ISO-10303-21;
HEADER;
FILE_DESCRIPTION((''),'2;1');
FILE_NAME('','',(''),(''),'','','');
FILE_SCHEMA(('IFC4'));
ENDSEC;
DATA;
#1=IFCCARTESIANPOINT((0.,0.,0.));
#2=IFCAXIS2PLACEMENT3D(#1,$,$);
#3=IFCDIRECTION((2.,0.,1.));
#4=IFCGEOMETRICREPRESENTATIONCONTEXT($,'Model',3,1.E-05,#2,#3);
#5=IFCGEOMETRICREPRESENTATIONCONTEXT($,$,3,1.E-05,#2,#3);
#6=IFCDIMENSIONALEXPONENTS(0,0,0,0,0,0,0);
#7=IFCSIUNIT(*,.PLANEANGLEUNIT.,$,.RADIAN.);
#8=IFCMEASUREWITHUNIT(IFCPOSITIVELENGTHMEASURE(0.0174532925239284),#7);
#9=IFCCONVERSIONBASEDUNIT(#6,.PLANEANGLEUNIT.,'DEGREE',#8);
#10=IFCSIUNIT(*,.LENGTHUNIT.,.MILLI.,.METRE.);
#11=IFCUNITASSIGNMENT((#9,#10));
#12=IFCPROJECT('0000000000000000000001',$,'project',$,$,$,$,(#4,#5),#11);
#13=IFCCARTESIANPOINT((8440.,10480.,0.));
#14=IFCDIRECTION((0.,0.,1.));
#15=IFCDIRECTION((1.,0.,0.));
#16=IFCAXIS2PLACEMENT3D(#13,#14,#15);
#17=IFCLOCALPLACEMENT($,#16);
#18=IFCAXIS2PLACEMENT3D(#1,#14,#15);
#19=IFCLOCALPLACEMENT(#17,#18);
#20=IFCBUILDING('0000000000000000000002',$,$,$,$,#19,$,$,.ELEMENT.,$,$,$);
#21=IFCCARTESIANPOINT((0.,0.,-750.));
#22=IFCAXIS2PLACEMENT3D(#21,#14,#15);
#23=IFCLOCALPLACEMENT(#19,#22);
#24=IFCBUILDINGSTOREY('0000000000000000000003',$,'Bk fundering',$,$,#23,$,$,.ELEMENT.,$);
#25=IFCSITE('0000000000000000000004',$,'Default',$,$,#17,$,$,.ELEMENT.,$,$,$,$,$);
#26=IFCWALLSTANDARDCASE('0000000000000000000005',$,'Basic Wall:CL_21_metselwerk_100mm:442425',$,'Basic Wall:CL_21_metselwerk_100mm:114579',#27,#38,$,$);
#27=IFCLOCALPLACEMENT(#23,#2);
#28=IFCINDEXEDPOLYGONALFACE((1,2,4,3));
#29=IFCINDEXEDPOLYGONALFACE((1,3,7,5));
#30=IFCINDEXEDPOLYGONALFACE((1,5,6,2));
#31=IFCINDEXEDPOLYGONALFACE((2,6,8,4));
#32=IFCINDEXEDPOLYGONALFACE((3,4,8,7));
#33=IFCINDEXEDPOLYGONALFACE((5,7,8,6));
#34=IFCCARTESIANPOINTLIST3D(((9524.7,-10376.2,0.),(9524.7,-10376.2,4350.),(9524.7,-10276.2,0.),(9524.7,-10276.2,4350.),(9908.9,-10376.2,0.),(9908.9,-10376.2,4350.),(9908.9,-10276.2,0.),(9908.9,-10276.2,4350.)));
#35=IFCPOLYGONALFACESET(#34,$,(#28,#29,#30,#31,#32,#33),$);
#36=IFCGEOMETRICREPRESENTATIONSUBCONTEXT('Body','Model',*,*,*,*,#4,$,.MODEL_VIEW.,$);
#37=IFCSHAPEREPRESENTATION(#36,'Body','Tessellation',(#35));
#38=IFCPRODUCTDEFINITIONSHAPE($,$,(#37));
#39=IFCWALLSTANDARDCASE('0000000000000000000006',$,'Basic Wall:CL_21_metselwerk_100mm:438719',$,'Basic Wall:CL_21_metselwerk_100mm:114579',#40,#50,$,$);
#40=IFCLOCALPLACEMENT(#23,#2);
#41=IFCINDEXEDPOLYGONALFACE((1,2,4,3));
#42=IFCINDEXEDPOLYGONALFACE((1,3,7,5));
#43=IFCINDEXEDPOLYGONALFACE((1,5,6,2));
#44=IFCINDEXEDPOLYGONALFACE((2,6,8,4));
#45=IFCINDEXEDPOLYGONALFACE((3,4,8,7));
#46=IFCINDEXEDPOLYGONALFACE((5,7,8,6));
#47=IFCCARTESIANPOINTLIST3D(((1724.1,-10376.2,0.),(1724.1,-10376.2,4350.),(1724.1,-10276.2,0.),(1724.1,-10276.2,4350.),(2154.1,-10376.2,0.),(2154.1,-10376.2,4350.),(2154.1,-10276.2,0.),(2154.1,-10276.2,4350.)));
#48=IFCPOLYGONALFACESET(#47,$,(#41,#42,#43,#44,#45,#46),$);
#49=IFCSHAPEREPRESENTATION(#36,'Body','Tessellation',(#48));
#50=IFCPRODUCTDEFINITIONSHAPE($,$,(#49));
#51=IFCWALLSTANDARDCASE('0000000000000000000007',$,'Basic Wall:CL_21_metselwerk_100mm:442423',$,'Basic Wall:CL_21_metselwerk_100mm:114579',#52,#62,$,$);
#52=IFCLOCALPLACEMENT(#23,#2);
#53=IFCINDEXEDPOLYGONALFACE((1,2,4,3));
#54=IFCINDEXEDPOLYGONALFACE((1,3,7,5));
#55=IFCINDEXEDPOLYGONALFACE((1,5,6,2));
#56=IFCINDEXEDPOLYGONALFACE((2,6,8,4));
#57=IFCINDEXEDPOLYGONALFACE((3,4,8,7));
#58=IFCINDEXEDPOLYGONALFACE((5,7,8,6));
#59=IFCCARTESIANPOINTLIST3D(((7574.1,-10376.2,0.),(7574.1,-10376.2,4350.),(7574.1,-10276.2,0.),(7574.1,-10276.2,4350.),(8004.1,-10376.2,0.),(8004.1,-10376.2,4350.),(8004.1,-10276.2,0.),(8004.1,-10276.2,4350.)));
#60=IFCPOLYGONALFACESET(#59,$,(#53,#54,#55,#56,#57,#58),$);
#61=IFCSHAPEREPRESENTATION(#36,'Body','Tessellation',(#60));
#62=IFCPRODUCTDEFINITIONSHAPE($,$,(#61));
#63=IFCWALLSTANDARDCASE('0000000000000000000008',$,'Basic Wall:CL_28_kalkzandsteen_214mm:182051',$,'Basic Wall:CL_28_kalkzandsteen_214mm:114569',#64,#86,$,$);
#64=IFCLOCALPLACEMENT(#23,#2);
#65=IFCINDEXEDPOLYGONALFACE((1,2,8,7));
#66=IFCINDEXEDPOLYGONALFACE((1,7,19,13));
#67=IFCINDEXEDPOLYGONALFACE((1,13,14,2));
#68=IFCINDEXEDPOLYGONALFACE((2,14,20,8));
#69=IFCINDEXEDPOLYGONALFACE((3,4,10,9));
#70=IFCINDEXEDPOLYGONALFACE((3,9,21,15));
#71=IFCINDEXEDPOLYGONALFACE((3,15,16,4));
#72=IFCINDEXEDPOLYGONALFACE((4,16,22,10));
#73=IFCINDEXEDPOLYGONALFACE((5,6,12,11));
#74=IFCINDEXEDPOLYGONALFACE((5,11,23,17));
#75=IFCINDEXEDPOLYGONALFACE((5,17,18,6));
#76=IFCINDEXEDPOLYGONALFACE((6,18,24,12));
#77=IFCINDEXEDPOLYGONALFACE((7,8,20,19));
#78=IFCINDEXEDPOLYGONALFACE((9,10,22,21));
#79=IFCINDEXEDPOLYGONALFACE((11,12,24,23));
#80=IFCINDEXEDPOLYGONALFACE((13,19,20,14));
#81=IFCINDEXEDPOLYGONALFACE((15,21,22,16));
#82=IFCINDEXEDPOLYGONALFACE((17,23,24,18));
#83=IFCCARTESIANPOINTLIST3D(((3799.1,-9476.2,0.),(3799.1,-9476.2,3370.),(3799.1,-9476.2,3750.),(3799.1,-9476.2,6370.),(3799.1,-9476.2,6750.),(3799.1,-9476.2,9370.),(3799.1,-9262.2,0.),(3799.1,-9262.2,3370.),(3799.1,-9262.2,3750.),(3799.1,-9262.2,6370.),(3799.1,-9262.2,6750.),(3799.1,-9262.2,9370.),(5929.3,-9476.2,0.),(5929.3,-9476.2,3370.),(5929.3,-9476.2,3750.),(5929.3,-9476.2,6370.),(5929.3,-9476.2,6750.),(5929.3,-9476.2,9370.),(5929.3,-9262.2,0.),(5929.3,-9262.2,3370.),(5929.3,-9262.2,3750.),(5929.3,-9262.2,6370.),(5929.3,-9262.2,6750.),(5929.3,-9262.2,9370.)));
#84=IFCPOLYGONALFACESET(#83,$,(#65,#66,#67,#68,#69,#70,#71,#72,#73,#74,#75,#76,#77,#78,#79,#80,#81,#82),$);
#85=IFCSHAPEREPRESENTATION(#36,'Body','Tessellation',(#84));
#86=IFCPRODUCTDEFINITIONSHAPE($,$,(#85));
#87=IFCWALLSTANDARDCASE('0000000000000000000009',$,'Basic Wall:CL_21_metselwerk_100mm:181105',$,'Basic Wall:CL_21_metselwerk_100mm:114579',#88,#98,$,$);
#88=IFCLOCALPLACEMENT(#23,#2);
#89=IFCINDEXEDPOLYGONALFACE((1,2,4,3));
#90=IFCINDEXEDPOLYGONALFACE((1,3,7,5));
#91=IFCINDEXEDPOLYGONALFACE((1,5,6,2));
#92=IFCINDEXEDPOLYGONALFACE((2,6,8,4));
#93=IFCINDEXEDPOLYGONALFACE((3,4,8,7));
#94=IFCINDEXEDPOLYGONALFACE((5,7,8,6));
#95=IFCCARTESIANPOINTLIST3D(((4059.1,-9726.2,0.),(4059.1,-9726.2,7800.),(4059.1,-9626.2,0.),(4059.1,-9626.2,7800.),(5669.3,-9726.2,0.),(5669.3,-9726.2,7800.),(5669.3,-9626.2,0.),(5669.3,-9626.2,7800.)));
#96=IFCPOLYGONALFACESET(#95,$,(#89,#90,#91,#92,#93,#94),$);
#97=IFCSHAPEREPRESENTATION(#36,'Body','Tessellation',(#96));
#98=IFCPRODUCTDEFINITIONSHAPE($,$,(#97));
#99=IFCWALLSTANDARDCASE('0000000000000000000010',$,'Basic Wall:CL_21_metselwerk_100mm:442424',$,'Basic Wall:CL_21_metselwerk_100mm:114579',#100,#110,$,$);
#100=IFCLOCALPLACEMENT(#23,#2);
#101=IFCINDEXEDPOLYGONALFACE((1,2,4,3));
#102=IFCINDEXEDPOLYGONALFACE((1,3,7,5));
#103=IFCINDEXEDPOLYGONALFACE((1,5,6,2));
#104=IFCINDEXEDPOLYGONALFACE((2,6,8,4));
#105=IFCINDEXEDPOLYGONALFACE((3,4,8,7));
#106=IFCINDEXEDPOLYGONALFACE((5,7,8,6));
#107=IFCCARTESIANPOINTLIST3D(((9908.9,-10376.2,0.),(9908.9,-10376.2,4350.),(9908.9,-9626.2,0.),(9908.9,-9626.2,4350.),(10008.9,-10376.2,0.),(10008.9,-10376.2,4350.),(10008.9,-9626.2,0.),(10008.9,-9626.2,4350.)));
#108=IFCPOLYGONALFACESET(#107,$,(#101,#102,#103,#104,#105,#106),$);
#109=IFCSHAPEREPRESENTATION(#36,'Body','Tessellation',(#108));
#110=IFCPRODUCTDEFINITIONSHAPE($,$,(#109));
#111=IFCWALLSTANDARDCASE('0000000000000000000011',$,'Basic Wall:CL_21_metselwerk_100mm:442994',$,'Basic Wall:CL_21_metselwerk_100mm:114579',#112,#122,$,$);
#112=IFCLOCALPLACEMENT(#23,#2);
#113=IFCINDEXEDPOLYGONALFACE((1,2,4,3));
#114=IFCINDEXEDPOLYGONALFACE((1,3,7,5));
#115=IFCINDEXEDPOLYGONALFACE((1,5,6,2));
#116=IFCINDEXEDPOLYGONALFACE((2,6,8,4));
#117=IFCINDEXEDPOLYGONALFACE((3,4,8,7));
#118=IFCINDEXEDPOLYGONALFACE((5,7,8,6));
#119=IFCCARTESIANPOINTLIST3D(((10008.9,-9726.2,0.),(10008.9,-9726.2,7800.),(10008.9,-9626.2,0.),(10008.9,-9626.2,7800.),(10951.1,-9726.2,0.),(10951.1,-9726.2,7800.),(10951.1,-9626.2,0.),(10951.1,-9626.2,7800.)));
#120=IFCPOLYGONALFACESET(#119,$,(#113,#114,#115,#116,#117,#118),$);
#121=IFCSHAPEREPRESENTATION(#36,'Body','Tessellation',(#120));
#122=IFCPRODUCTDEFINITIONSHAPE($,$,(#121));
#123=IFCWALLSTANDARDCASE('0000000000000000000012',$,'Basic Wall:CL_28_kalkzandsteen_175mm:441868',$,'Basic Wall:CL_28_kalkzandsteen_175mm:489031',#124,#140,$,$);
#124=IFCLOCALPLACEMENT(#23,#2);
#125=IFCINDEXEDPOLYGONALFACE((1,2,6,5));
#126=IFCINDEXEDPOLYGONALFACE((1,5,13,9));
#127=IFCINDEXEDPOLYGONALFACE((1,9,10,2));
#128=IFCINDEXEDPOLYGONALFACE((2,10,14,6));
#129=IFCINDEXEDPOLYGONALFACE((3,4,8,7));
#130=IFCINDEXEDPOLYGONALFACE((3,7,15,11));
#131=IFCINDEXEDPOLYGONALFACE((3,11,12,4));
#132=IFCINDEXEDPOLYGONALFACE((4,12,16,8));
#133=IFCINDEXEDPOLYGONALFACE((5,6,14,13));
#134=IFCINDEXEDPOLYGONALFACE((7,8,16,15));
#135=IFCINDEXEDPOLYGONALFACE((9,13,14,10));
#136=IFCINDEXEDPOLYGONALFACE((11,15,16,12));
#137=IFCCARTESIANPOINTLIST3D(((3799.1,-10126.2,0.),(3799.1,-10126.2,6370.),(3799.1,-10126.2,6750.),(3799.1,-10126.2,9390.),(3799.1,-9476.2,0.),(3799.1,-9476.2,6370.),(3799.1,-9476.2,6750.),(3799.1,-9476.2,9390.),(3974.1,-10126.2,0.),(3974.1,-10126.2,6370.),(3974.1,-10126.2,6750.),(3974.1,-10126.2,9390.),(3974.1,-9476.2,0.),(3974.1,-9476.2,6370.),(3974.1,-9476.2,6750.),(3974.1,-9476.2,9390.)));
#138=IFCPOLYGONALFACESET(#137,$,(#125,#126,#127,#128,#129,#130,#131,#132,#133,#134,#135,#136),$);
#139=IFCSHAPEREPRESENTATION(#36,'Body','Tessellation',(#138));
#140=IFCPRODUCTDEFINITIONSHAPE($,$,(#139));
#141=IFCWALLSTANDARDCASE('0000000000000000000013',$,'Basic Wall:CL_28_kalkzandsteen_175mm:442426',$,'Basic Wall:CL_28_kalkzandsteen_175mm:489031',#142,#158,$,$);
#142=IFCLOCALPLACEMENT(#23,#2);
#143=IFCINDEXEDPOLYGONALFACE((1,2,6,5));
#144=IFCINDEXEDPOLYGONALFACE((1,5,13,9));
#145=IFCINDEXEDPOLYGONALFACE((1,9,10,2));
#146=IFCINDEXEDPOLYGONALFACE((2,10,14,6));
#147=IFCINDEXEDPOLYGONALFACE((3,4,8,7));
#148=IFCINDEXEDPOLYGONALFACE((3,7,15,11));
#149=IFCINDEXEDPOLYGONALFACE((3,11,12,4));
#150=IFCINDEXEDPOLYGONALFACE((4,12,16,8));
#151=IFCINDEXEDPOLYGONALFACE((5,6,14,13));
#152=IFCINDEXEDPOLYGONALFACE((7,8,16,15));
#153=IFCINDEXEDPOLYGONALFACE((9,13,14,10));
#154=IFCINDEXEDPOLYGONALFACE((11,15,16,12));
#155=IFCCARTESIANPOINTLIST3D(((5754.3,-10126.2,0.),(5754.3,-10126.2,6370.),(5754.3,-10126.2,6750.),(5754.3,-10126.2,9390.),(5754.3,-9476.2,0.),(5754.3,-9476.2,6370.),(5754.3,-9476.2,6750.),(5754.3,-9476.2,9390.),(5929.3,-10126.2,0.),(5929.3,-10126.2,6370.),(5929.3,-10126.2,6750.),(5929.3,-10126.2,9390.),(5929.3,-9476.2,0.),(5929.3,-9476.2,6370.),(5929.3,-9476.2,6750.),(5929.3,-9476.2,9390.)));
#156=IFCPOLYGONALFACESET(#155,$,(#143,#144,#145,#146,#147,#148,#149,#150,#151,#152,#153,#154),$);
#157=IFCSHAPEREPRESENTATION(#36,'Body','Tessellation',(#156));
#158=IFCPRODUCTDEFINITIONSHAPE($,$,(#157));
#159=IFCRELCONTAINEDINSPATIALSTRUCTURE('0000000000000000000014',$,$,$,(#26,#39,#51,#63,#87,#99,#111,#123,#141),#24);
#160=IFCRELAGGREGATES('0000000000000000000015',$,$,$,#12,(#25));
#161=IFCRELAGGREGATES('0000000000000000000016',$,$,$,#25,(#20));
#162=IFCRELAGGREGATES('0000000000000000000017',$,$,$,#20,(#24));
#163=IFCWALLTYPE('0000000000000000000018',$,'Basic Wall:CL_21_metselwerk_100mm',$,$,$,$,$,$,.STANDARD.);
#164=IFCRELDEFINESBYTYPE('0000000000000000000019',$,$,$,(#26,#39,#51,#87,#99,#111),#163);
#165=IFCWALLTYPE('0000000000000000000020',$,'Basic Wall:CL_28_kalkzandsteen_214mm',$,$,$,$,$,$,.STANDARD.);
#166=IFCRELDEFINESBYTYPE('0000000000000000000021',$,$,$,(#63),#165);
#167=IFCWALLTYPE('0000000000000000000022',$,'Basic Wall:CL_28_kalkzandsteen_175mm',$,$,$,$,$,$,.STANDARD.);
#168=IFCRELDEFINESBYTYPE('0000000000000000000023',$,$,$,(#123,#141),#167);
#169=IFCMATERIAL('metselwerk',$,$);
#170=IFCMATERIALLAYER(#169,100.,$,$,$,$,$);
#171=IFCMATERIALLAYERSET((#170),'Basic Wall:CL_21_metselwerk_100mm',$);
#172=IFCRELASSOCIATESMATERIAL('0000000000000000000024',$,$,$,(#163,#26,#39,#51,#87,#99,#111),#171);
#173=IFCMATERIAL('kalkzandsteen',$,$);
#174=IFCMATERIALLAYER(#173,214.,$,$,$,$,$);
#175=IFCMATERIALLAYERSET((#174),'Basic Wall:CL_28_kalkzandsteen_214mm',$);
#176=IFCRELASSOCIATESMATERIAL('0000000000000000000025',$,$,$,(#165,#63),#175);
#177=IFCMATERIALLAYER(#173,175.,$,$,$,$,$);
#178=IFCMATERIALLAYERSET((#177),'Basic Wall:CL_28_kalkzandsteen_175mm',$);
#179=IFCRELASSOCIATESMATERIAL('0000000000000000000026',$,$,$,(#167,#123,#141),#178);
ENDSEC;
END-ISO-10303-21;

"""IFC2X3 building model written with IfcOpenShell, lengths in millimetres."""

from ifc_helpers import new_model, entity, si_unit, converted_unit, direction, frame, frame_2d, origin, origin_with_axes, place, context, subcontext, project, spatial, polyline, rectangle, extrude, clip, bounded_halfspace, source, transform, mapped, material, layer, layer_set, layer_usage, type_object, element, save


model = new_model("IFC2X3")

# Units and contexts
model_context = context("Model", 3, precision=1e-05, world=origin(), true_north=direction((2.0, 0.0, 1.0)))
context_of_model = context(None, 3, precision=1e-05, world=origin(), true_north=direction((2.0, 0.0, 1.0)))
body_context = subcontext(model_context, "Body", "Model", "MODEL_VIEW")
ifc_project = project(units=[converted_unit("PLANEANGLEUNIT", "DEGREE", entity("IfcPositiveLengthMeasure", 0.0174532925239284), si_unit("PLANEANGLEUNIT", "RADIAN"), dimensions=[0, 0, 0, 0, 0, 0, 0]), si_unit("LENGTHUNIT", "METRE", prefix="MILLI")], contexts=[model_context, context_of_model])

# Site, building, storey
site_placement = place(None, frame((8440.0, 10480.0, 0.0), z_axis=(0.0, 0.0, 1.0), x_axis=(1.0, 0.0, 0.0)))
site = spatial("IfcSite", under=ifc_project, at=site_placement, Name="Default", CompositionType="ELEMENT")
building_placement = place(site_placement, origin_with_axes())
building = spatial("IfcBuilding", under=site, at=building_placement, CompositionType="ELEMENT")
storey_placement = place(building_placement, frame((0.0, 0.0, -750.0), z_axis=(0.0, 0.0, 1.0), x_axis=(1.0, 0.0, 0.0)))
storey = spatial("IfcBuildingStorey", under=building, at=storey_placement, Name="Bk fundering", CompositionType="ELEMENT")

# Walls
ifc_material_1 = material(Name="metselwerk")
ifc_layer_1 = layer(ifc_material_1, 100.0)
ifc_layer_set_1 = layer_set([ifc_layer_1], Name="Basic Wall:CL_21_metselwerk_100mm")
wall_type_1 = type_object("IfcWallType", Name="Basic Wall:CL_21_metselwerk_100mm", PredefinedType="STANDARD", material=ifc_layer_set_1)
ifc_material_2 = material(Name="kalkzandsteen")
ifc_layer_2 = layer(ifc_material_2, 214.0)
ifc_layer_set_2 = layer_set([ifc_layer_2], Name="Basic Wall:CL_28_kalkzandsteen_214mm")
wall_type_2 = type_object("IfcWallType", Name="Basic Wall:CL_28_kalkzandsteen_214mm", PredefinedType="STANDARD", material=ifc_layer_set_2)
shared_shape_1 = source(origin(), body_context, "Body", "SweptSolid", [
    extrude(rectangle(XDim=384.2, YDim=100.0, at=frame_2d((192.1, 0.0), x_axis=(-1.0, 0.0))), origin(), (0.0, 0.0, 1.0), 4350.0),
])
ifc_layer_usage_1 = layer_usage(ifc_layer_set_1, "AXIS2", "POSITIVE", -50.0)
wall_1_placement = place(storey_placement, frame((9908.9, -10326.2, 0.0), z_axis=(0.0, 0.0, 1.0), x_axis=(-1.0, 0.0, 0.0)))
element("IfcWallStandardCase", 1, at=wall_1_placement, inside=storey, type_object=wall_type_1, material=ifc_layer_usage_1, Name="Basic Wall:CL_21_metselwerk_100mm:442425", ObjectType="Basic Wall:CL_21_metselwerk_100mm:114579", context=body_context, shape_type="MappedRepresentation", body=[
    mapped(shared_shape_1, transform((0.0, 0.0, 0.0))),
])
ifc_layer_usage_2 = layer_usage(ifc_layer_set_1, "AXIS2", "NEGATIVE", 50.0)
shared_shape_2 = source(origin(), body_context, "Body", "SweptSolid", [
    extrude(rectangle(XDim=430.0, YDim=100.0, at=frame_2d((215.0, 0.0), x_axis=(-1.0, 0.0))), origin(), (0.0, 0.0, 1.0), 4350.0),
])
wall_2_placement = place(storey_placement, frame((1724.1, -10326.2, 0.0), z_axis=(0.0, 0.0, 1.0), x_axis=(1.0, 0.0, 0.0)))
element("IfcWallStandardCase", 2, at=wall_2_placement, inside=storey, type_object=wall_type_1, material=ifc_layer_usage_2, Name="Basic Wall:CL_21_metselwerk_100mm:438719", ObjectType="Basic Wall:CL_21_metselwerk_100mm:114579", context=body_context, shape_type="MappedRepresentation", body=[
    mapped(shared_shape_2, transform((0.0, 0.0, 0.0))),
])
ifc_layer_usage_3 = layer_usage(ifc_layer_set_1, "AXIS2", "NEGATIVE", 50.0)
wall_3_placement = place(storey_placement, frame((7574.1, -10326.2, 0.0), z_axis=(0.0, 0.0, 1.0), x_axis=(1.0, 0.0, 0.0)))
element("IfcWallStandardCase", 3, at=wall_3_placement, inside=storey, type_object=wall_type_1, material=ifc_layer_usage_3, Name="Basic Wall:CL_21_metselwerk_100mm:442423", ObjectType="Basic Wall:CL_21_metselwerk_100mm:114579", context=body_context, shape_type="MappedRepresentation", body=[
    mapped(shared_shape_2, transform((0.0, 0.0, 0.0))),
])

# Wall, openings
ifc_layer_usage_4 = layer_usage(ifc_layer_set_2, "AXIS2", "NEGATIVE", 107.0)
wall_4_placement = place(storey_placement, frame((3799.1, -9369.2, 0.0), z_axis=(0.0, 0.0, 1.0), x_axis=(1.0, 0.0, 0.0)))
wall_4 = element("IfcWallStandardCase", 4, at=wall_4_placement, inside=storey, type_object=wall_type_2, material=ifc_layer_usage_4, Name="Basic Wall:CL_28_kalkzandsteen_214mm:182051", ObjectType="Basic Wall:CL_28_kalkzandsteen_214mm:114569", context=body_context, shape_type="Clipping", body=[
    clip(extrude(rectangle(XDim=2130.2, YDim=214.0, at=frame_2d((1065.1, 0.0), x_axis=(-1.0, 0.0))), origin(), (0.0, 0.0, 1.0), 9370.0), bounded_halfspace(frame((2130.2, 107.0, 9370.0), z_axis=(0.0, 0.0, -1.0), x_axis=(1.0, 0.0, 0.0)), True, frame((2130.2, 107.0, 9370.0)), polyline([(0.0, 0.0), (-2130.2, 0.0), (-2130.2, -214.0), (-1955.2, -214.0), (-175.0, -214.0), (0.0, -214.0), (0.0, 0.0)]))),
])
opening_1_placement = place(wall_4_placement, origin_with_axes())
element("IfcOpeningElement", 5, at=opening_1_placement, cuts=wall_4, ObjectType="Opening", context=body_context, shape_type="SweptSolid", body=[
    extrude(rectangle(XDim=2130.2, YDim=214.0, at=frame_2d((0.0, 35.7), x_axis=(1.0, 0.0))), frame((1065.1, -35.7, 6370.0)), (0.0, 0.0, 1.0), 380.0),
])
opening_2_placement = place(wall_4_placement, origin_with_axes())
element("IfcOpeningElement", 6, at=opening_2_placement, cuts=wall_4, ObjectType="Opening", context=body_context, shape_type="SweptSolid", body=[
    extrude(rectangle(XDim=2130.2, YDim=214.0, at=frame_2d((-75.0, 0.0), x_axis=(1.0, 0.0))), frame((1140.1, 0.0, 3370.0)), (0.0, 0.0, 1.0), 380.0),
])

# Walls
ifc_layer_usage_5 = layer_usage(ifc_layer_set_1, "AXIS2", "NEGATIVE", 50.0)
wall_5_placement = place(storey_placement, frame((4059.1, -9676.2, 0.0), z_axis=(0.0, 0.0, 1.0), x_axis=(1.0, 0.0, 0.0)))
element("IfcWallStandardCase", 7, at=wall_5_placement, inside=storey, type_object=wall_type_1, material=ifc_layer_usage_5, Name="Basic Wall:CL_21_metselwerk_100mm:181105", ObjectType="Basic Wall:CL_21_metselwerk_100mm:114579", context=body_context, shape_type="SweptSolid", body=[
    extrude(rectangle(XDim=1610.2, YDim=100.0, at=frame_2d((805.1, 0.0), x_axis=(-1.0, 0.0))), origin(), (0.0, 0.0, 1.0), 7800.0),
])
ifc_layer_usage_6 = layer_usage(ifc_layer_set_1, "AXIS2", "POSITIVE", -50.0)
wall_6_placement = place(storey_placement, frame((9958.9, -9626.2, 0.0), z_axis=(0.0, 0.0, 1.0), x_axis=(0.0, -1.0, 0.0)))
element("IfcWallStandardCase", 8, at=wall_6_placement, inside=storey, type_object=wall_type_1, material=ifc_layer_usage_6, Name="Basic Wall:CL_21_metselwerk_100mm:442424", ObjectType="Basic Wall:CL_21_metselwerk_100mm:114579", context=body_context, shape_type="SweptSolid", body=[
    extrude(rectangle(XDim=750.0, YDim=100.0, at=frame_2d((375.0, 0.0), x_axis=(-1.0, 0.0))), origin(), (0.0, 0.0, 1.0), 4350.0),
])
ifc_layer_usage_7 = layer_usage(ifc_layer_set_1, "AXIS2", "POSITIVE", -50.0)
wall_7_placement = place(storey_placement, frame((10951.1, -9676.2, 0.0), z_axis=(0.0, 0.0, 1.0), x_axis=(-1.0, 0.0, 0.0)))
element("IfcWallStandardCase", 9, at=wall_7_placement, inside=storey, type_object=wall_type_1, material=ifc_layer_usage_7, Name="Basic Wall:CL_21_metselwerk_100mm:442994", ObjectType="Basic Wall:CL_21_metselwerk_100mm:114579", context=body_context, shape_type="SweptSolid", body=[
    extrude(rectangle(XDim=942.2, YDim=100.0, at=frame_2d((471.1, 0.0), x_axis=(-1.0, 0.0))), origin(), (0.0, 0.0, 1.0), 7800.0),
])

# Walls, openings
ifc_layer_3 = layer(ifc_material_2, 175.0)
ifc_layer_set_3 = layer_set([ifc_layer_3], Name="Basic Wall:CL_28_kalkzandsteen_175mm")
ifc_layer_usage_8 = layer_usage(ifc_layer_set_3, "AXIS2", "POSITIVE", -87.5)
wall_type_3 = type_object("IfcWallType", Name="Basic Wall:CL_28_kalkzandsteen_175mm", PredefinedType="STANDARD", material=ifc_layer_set_3)
wall_8_placement = place(storey_placement, frame((3886.6, -9476.2, 0.0), z_axis=(0.0, 0.0, 1.0), x_axis=(0.0, -1.0, 0.0)))
wall_8 = element("IfcWallStandardCase", 10, at=wall_8_placement, inside=storey, type_object=wall_type_3, material=ifc_layer_usage_8, Name="Basic Wall:CL_28_kalkzandsteen_175mm:441868", ObjectType="Basic Wall:CL_28_kalkzandsteen_175mm:489031", context=body_context, shape_type="SweptSolid", body=[
    extrude(rectangle(XDim=650.0, YDim=175.0, at=frame_2d((325.0, 0.0), x_axis=(-1.0, 0.0))), origin(), (0.0, 0.0, 1.0), 9390.0),
])
shared_shape_3 = source(origin(), body_context, "Body", "SweptSolid", [
    extrude(rectangle(XDim=650.0, YDim=175.0, at=frame_2d((0.0, 0.0), x_axis=(1.0, 0.0))), frame((325.0, 0.0, 6370.0)), (0.0, 0.0, 1.0), 380.0),
])
opening_3_placement = place(wall_8_placement, origin_with_axes())
element("IfcOpeningElement", 11, at=opening_3_placement, cuts=wall_8, ObjectType="Opening", context=body_context, shape_type="MappedRepresentation", body=[
    mapped(shared_shape_3, transform((0.0, 0.0, 0.0))),
])
ifc_layer_usage_9 = layer_usage(ifc_layer_set_3, "AXIS2", "NEGATIVE", 87.5)
wall_9_placement = place(storey_placement, frame((5841.8, -9476.2, 0.0), z_axis=(0.0, 0.0, 1.0), x_axis=(0.0, -1.0, 0.0)))
wall_9 = element("IfcWallStandardCase", 12, at=wall_9_placement, inside=storey, type_object=wall_type_3, material=ifc_layer_usage_9, Name="Basic Wall:CL_28_kalkzandsteen_175mm:442426", ObjectType="Basic Wall:CL_28_kalkzandsteen_175mm:489031", context=body_context, shape_type="SweptSolid", body=[
    extrude(rectangle(XDim=650.0, YDim=175.0, at=frame_2d((325.0, 0.0), x_axis=(-1.0, 0.0))), origin(), (0.0, 0.0, 1.0), 9390.0),
])
opening_4_placement = place(wall_9_placement, origin_with_axes())
element("IfcOpeningElement", 13, at=opening_4_placement, cuts=wall_9, ObjectType="Opening", context=body_context, shape_type="MappedRepresentation", body=[
    mapped(shared_shape_3, transform((0.0, 0.0, 0.0))),
])

save(model, "model.ifc")
